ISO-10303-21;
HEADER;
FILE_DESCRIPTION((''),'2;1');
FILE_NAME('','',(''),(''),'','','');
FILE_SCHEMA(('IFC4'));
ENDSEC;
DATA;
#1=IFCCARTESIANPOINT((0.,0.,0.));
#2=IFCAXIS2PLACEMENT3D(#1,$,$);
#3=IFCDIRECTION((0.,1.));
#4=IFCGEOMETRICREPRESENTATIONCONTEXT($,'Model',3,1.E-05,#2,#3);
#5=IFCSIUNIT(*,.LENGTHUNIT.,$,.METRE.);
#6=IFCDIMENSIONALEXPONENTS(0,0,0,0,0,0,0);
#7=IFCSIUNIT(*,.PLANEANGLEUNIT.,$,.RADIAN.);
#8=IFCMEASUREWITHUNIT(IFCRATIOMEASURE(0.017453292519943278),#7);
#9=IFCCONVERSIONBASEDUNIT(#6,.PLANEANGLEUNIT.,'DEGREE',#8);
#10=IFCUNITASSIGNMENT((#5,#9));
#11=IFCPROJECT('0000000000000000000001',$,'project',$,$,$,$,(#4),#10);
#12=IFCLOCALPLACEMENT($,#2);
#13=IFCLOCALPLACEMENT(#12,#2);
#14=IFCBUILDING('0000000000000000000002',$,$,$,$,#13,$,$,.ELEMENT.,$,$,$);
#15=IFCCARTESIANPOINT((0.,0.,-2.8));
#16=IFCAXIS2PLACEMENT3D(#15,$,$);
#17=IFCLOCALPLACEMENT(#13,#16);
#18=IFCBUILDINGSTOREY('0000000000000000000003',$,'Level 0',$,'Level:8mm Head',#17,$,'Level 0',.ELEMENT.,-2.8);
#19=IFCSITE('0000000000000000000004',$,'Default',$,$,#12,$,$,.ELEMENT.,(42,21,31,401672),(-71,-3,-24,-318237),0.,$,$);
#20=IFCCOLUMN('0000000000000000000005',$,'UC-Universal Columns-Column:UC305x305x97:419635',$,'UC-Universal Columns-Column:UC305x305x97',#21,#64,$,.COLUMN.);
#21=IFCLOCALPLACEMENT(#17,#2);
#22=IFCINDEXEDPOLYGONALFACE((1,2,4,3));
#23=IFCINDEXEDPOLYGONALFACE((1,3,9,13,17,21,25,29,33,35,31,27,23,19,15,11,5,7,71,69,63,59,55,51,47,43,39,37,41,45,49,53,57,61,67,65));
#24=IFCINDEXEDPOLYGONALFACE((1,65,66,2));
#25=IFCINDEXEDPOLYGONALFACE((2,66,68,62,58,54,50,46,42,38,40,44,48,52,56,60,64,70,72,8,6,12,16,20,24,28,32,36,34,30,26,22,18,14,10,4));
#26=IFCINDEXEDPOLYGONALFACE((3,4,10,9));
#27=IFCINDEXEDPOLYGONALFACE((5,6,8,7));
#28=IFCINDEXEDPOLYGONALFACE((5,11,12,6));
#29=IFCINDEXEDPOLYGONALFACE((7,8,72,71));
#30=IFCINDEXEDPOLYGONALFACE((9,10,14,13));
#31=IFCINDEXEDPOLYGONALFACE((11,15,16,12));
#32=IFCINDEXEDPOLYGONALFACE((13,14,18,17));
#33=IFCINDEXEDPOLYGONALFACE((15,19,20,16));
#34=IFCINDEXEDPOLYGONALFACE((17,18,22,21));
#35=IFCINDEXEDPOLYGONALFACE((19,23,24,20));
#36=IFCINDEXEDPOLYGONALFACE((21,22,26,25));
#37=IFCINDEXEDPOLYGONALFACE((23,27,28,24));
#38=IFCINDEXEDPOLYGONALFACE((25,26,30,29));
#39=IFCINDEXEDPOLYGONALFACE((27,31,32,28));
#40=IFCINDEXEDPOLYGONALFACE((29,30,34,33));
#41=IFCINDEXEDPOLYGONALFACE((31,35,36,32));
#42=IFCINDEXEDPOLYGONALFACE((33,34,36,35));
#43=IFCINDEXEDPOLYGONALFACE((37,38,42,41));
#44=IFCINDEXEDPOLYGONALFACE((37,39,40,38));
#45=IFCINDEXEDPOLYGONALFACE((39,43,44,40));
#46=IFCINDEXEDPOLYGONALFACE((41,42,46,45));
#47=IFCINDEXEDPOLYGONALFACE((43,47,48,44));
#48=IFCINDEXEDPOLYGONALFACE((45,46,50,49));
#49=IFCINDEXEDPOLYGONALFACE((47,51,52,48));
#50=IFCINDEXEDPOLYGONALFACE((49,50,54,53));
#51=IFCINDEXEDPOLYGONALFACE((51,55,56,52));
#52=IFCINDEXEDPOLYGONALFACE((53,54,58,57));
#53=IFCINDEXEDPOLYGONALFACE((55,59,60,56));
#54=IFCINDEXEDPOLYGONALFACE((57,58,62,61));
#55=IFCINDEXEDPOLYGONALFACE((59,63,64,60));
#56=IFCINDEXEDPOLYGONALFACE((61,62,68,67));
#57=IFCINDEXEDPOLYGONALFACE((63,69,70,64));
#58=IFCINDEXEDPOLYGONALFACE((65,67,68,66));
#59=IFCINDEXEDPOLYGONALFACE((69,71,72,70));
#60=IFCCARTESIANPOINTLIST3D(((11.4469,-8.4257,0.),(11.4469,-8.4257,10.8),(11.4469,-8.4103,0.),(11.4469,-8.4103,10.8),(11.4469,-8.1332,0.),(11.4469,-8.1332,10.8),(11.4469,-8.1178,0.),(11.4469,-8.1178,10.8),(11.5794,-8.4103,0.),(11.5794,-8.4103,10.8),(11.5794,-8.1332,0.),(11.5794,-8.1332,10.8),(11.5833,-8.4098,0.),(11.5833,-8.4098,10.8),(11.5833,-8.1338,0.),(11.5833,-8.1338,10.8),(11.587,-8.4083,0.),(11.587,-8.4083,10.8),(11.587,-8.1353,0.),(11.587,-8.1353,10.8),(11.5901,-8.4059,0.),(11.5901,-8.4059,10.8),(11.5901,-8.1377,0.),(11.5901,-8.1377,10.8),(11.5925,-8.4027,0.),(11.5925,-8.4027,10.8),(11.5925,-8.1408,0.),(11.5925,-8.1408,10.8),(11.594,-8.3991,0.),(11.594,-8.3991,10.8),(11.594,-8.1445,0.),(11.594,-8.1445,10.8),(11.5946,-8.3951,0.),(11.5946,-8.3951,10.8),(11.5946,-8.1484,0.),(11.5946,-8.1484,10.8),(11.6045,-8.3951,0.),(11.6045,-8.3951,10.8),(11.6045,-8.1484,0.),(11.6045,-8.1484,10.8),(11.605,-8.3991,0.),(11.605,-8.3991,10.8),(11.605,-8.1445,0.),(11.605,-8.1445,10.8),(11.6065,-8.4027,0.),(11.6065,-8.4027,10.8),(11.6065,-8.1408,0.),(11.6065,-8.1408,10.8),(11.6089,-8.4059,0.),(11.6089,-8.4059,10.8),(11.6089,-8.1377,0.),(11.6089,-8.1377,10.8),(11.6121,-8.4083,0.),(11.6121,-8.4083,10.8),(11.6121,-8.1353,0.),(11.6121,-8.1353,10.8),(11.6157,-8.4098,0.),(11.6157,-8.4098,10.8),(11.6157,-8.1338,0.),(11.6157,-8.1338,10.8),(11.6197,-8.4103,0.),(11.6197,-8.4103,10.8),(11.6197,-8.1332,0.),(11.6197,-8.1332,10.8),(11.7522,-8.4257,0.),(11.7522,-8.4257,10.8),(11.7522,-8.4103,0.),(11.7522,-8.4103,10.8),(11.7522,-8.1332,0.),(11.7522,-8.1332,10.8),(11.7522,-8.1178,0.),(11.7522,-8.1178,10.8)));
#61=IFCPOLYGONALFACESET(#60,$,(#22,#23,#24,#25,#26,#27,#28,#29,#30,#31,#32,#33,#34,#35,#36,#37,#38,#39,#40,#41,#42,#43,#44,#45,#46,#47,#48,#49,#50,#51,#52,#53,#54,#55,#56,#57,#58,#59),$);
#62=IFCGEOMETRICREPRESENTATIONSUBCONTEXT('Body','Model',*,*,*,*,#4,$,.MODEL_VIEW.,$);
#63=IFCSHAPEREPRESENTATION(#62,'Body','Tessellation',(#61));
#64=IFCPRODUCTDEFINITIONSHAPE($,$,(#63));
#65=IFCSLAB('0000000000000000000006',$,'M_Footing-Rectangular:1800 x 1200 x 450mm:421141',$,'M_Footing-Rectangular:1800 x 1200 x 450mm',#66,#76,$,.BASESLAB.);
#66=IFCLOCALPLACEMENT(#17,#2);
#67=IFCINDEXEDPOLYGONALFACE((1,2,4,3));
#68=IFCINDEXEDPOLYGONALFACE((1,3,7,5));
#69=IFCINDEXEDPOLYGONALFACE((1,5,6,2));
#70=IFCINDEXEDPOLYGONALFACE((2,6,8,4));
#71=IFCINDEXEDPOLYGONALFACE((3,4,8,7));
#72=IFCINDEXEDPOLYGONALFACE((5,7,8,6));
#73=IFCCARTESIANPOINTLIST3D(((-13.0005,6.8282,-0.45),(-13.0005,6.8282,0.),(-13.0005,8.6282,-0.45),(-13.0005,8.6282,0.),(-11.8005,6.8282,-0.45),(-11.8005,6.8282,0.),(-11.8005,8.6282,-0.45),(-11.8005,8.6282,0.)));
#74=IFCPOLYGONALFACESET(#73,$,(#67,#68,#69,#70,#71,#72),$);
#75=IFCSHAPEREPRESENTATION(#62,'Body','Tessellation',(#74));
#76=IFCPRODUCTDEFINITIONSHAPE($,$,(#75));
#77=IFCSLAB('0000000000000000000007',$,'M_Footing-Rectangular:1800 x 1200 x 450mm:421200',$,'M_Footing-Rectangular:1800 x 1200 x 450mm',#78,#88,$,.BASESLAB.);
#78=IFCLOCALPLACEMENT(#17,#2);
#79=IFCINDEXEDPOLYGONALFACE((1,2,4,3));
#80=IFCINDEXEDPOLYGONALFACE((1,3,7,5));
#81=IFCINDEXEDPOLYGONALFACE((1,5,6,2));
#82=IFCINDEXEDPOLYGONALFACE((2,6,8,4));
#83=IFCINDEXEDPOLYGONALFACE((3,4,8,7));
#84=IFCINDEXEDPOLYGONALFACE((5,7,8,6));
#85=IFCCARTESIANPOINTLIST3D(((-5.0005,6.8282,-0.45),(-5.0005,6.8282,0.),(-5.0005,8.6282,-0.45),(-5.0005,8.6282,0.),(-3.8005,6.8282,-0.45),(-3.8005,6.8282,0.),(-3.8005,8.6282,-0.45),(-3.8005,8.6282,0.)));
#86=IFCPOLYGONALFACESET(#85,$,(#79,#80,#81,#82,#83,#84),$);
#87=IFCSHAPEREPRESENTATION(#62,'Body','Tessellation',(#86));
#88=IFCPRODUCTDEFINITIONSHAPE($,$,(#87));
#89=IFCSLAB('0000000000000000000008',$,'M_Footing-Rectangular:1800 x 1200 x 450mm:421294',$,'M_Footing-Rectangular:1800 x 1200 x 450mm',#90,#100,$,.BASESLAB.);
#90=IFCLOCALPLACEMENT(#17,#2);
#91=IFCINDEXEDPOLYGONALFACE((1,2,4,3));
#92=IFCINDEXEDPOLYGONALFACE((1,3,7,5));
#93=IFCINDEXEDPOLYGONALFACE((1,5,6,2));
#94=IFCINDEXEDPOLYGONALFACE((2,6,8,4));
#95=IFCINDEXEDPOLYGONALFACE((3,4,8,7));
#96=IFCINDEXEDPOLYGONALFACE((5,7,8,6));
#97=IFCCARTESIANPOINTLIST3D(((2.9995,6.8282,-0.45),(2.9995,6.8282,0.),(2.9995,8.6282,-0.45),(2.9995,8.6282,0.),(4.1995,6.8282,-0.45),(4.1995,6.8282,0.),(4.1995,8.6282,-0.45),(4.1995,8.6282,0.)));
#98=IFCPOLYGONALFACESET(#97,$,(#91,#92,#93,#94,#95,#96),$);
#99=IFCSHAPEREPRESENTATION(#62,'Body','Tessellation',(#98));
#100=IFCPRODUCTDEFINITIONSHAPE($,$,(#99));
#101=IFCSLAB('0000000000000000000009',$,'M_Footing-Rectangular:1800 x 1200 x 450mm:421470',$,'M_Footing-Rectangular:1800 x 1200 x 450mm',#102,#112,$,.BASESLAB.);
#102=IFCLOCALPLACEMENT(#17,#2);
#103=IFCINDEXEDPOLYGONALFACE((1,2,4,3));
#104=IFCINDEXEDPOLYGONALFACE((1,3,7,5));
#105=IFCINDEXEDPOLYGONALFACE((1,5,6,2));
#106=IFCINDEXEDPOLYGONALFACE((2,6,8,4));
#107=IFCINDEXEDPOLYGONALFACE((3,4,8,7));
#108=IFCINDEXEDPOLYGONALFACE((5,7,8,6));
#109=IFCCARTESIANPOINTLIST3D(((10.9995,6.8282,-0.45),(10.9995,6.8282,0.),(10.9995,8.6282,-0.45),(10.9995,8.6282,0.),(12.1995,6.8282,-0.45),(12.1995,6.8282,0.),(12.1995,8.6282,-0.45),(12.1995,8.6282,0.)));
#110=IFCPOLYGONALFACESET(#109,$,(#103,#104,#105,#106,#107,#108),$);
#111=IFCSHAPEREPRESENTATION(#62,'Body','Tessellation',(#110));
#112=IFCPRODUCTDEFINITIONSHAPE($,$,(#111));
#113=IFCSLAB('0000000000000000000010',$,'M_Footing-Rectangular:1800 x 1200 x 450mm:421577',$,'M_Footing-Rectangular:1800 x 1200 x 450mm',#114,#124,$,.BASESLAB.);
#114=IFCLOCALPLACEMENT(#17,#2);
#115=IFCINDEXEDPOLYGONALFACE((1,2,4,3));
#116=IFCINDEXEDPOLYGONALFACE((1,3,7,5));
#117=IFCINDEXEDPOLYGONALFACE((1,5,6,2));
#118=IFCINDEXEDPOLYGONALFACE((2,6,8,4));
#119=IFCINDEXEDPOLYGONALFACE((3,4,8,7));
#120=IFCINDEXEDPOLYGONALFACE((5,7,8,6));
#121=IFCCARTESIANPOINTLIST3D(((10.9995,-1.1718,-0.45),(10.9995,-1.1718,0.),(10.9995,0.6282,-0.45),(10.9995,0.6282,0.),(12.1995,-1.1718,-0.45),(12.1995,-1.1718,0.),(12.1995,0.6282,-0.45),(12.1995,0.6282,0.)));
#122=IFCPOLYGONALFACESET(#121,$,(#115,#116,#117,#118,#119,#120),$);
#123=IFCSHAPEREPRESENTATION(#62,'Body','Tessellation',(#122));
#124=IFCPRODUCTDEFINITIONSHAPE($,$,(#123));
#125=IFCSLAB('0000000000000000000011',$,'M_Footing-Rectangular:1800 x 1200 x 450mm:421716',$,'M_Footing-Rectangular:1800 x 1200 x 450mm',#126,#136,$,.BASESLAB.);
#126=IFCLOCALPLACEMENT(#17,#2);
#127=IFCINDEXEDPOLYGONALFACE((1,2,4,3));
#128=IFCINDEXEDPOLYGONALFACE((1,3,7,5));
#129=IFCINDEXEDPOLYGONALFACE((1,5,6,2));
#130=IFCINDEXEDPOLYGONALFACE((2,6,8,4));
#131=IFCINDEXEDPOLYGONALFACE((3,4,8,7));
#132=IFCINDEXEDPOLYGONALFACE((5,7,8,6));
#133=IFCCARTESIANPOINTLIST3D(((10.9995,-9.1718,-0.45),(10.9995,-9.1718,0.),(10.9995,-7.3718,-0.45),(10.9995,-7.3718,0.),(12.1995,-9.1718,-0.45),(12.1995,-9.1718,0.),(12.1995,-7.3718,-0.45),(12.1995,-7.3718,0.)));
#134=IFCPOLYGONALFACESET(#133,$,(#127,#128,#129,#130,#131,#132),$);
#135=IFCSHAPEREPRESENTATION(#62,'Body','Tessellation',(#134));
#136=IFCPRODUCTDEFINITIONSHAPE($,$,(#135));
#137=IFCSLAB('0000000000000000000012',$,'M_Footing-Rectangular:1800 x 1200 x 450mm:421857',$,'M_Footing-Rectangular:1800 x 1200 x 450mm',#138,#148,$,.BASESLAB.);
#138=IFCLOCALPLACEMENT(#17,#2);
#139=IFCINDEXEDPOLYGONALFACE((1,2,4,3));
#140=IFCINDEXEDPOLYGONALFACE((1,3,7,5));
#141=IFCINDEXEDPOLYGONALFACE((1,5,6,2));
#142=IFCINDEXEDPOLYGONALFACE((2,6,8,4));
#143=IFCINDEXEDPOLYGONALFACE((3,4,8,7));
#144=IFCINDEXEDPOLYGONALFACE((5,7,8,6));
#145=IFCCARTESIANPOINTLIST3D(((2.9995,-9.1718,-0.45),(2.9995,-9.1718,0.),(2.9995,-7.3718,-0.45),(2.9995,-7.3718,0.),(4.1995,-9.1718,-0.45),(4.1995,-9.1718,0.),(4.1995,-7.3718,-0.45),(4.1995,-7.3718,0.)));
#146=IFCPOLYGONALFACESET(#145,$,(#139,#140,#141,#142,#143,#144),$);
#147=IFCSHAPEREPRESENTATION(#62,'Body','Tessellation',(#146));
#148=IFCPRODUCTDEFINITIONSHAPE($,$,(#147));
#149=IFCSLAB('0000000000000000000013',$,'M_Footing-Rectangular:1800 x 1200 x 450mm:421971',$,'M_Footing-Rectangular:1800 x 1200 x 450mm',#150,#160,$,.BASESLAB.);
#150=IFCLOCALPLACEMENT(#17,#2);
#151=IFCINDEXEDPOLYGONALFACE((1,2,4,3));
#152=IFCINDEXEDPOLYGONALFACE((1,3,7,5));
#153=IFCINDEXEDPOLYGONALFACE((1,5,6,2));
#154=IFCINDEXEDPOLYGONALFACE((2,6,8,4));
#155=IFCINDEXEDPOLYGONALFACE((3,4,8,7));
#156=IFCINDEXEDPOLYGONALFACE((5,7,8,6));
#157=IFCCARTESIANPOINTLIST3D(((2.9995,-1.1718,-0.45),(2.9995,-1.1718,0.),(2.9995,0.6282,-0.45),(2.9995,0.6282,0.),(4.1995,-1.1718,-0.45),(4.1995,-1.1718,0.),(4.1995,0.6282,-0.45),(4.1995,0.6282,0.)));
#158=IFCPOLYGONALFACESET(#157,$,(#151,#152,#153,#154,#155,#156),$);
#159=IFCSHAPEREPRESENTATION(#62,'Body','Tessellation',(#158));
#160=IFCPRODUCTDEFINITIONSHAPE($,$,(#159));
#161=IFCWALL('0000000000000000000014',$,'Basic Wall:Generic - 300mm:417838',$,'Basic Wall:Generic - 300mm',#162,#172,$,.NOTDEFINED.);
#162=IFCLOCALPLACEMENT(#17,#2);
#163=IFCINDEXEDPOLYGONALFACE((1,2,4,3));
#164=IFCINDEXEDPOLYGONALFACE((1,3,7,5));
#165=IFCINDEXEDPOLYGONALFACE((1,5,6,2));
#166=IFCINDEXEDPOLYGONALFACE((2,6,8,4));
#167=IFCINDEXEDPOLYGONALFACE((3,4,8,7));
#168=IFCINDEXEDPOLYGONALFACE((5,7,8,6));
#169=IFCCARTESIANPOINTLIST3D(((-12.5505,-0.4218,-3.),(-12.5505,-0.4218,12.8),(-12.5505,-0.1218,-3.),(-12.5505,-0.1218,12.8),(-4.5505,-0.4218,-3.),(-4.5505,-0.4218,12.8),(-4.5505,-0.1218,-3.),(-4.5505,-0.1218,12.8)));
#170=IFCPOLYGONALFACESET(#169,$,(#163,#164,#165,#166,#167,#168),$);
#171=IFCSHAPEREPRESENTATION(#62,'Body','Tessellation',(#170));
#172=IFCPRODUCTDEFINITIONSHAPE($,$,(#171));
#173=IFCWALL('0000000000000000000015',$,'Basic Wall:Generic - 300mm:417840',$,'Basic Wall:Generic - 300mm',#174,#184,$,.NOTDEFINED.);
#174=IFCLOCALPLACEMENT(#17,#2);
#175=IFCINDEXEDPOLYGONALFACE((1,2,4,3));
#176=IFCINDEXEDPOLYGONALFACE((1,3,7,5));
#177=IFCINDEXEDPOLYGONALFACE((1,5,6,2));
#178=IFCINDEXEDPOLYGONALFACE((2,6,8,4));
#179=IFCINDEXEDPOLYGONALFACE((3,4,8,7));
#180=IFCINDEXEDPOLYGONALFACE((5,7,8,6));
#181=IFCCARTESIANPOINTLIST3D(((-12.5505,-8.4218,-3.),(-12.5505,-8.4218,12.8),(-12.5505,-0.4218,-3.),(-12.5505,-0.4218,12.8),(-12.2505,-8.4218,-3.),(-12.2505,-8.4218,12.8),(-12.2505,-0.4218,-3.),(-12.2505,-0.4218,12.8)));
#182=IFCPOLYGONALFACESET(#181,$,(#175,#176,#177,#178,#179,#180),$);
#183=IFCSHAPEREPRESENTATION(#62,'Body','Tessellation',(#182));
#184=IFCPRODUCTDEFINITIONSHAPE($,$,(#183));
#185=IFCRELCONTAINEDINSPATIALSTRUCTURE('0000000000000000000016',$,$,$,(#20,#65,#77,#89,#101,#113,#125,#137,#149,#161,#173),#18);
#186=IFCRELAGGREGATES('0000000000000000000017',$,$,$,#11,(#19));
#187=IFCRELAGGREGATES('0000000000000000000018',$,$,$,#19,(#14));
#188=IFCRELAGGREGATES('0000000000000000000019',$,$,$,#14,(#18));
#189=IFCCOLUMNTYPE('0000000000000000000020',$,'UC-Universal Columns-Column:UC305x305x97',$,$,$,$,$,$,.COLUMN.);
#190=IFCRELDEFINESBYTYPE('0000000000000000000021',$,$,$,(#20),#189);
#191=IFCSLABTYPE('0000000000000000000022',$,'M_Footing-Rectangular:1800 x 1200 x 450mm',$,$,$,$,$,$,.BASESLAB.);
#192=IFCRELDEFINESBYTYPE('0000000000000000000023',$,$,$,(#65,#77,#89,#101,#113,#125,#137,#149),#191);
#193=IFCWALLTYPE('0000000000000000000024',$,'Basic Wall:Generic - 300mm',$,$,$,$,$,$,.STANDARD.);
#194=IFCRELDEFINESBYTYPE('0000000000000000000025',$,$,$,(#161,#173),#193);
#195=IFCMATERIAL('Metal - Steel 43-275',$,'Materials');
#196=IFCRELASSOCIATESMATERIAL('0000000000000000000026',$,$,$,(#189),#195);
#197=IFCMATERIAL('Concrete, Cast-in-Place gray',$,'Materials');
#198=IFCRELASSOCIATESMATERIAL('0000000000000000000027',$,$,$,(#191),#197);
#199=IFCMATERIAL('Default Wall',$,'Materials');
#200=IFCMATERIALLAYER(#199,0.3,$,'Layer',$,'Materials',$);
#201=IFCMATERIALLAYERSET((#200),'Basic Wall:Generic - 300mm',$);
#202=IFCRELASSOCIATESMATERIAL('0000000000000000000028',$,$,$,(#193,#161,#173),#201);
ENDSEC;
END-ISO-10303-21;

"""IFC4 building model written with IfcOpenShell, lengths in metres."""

from ifc_helpers import new_model, entity, si_unit, converted_unit, direction, frame, frame_2d, origin, origin_2d_with_axis, place, context, subcontext, project, spatial, rectangle, i_section, extrude, source, transform, mapped, material, layer, layer_set, layer_usage, material_profile, profile_set, type_object, type_shapes, element, save


model = new_model("IFC4")

# Units and contexts
model_context = context("Model", 3, precision=1e-05, world=origin(), true_north=direction((0.0, 1.0)))
body_context = subcontext(model_context, "Body", "Model", "MODEL_VIEW")
ifc_project = project(units=[si_unit("LENGTHUNIT", "METRE"), converted_unit("PLANEANGLEUNIT", "DEGREE", entity("IfcRatioMeasure", 0.017453292519943278), si_unit("PLANEANGLEUNIT", "RADIAN"), dimensions=[0, 0, 0, 0, 0, 0, 0])], contexts=[model_context])

# Site, building, storey
site_placement = place(None, origin())
site = spatial("IfcSite", under=ifc_project, at=site_placement, Name="Default", CompositionType="ELEMENT", RefLatitude=(42, 21, 31, 401672), RefLongitude=(-71, -3, -24, -318237), RefElevation=0.0)
building_placement = place(site_placement, origin())
building = spatial("IfcBuilding", under=site, at=building_placement, CompositionType="ELEMENT")
storey_placement = place(building_placement, frame((0.0, 0.0, -2.8)))
storey = spatial("IfcBuildingStorey", under=building, at=storey_placement, Name="Level 0", ObjectType="Level:8mm Head", LongName="Level 0", CompositionType="ELEMENT", Elevation=-2.8)

# Column
ifc_material_1 = material(Name="Metal - Steel 43-275", Category="Materials")
ifc_material_profile = material_profile(ifc_material_1, i_section(OverallWidth=0.3053, OverallDepth=0.3079, WebThickness=0.0099, FlangeThickness=0.0154, FilletRadius=0.0152, at=frame_2d((0.0, 0.0), x_axis=(0.0, 1.0))), Name="UC305x305x97")
ifc_profile_set = profile_set([ifc_material_profile], Name="UC305x305x97")
column_type = type_object("IfcColumnType", Name="UC-Universal Columns-Column:UC305x305x97", PredefinedType="COLUMN", material=ifc_profile_set)
shared_shape = source(origin(), body_context, "Body", "SweptSolid", [
    extrude(i_section(OverallWidth=0.3053, OverallDepth=0.3079, WebThickness=0.0099, FlangeThickness=0.0154, FilletRadius=0.0152, at=frame_2d((0.0, 0.0), x_axis=(0.0, 1.0))), frame((0.0, 0.0, -2.8), z_axis=(0.0, 0.0, 1.0), x_axis=(0.0, -1.0, 0.0)), (0.0, 0.0, 1.0), 10.8),
])
type_shapes(column_type, [shared_shape])
for number, where, name in (
    (1, (11.5995, -8.2718, 2.8), "UC-Universal Columns-Column:UC305x305x97:419635"),
):
    element("IfcColumn", number, at=place(storey_placement, frame(where)), inside=storey, type_object=column_type, Name=name, ObjectType="UC-Universal Columns-Column:UC305x305x97", PredefinedType="COLUMN", context=body_context, shape_type="MappedRepresentation", body=[
        mapped(shared_shape, transform((0.0, 0.0, 0.0), scale=1.0)),
    ])

# Slabs
ifc_material_2 = material(Name="Concrete, Cast-in-Place gray", Category="Materials")
slab_type = type_object("IfcSlabType", Name="M_Footing-Rectangular:1800 x 1200 x 450mm", PredefinedType="BASESLAB", material=ifc_material_2)
slab_1_placement = place(storey_placement, frame((-13.0005, 6.8282, -0.45)))
element("IfcSlab", 2, at=slab_1_placement, inside=storey, type_object=slab_type, Name="M_Footing-Rectangular:1800 x 1200 x 450mm:421141", ObjectType="M_Footing-Rectangular:1800 x 1200 x 450mm", PredefinedType="BASESLAB", context=body_context, shape_type="SweptSolid", body=[
    extrude(rectangle(XDim=1.2, YDim=1.8, at=frame_2d((0.0, 0.0), x_axis=(1.0, 0.0))), frame((0.6, 0.9, 0.0), z_axis=(0.0, 0.0, 1.0), x_axis=(-1.0, 0.0, 0.0)), (0.0, 0.0, 1.0), 0.45),
])
for number, where, name in (
    (3, (-5.0005, 6.8282, -0.45), "M_Footing-Rectangular:1800 x 1200 x 450mm:421200"),
    (4, (2.9995, 6.8282, -0.45), "M_Footing-Rectangular:1800 x 1200 x 450mm:421294"),
):
    element("IfcSlab", number, at=place(storey_placement, frame(where)), inside=storey, type_object=slab_type, Name=name, ObjectType="M_Footing-Rectangular:1800 x 1200 x 450mm", PredefinedType="BASESLAB", context=body_context, shape_type="SweptSolid", body=[
        extrude(rectangle(XDim=1.2, YDim=1.8, at=frame_2d((0.0, 0.0), x_axis=(1.0, 0.0))), frame((0.6, 0.9, 0.0), z_axis=(0.0, 0.0, 1.0), x_axis=(-1.0, 0.0, 0.0)), (0.0, 0.0, 1.0), 0.45),
    ])
slab_2_placement = place(storey_placement, frame((10.9995, 6.8282, -0.45)))
element("IfcSlab", 5, at=slab_2_placement, inside=storey, type_object=slab_type, Name="M_Footing-Rectangular:1800 x 1200 x 450mm:421470", ObjectType="M_Footing-Rectangular:1800 x 1200 x 450mm", PredefinedType="BASESLAB", context=body_context, shape_type="SweptSolid", body=[
    extrude(rectangle(XDim=1.2, YDim=1.8, at=frame_2d((0.0, 0.0), x_axis=(1.0, 0.0))), frame((0.6, 0.9, 0.0), z_axis=(0.0, 0.0, 1.0), x_axis=(-1.0, 0.0, 0.0)), (0.0, 0.0, 1.0), 0.45),
])
slab_3_placement = place(storey_placement, frame((10.9995, -1.1718, -0.45)))
element("IfcSlab", 6, at=slab_3_placement, inside=storey, type_object=slab_type, Name="M_Footing-Rectangular:1800 x 1200 x 450mm:421577", ObjectType="M_Footing-Rectangular:1800 x 1200 x 450mm", PredefinedType="BASESLAB", context=body_context, shape_type="SweptSolid", body=[
    extrude(rectangle(XDim=1.2, YDim=1.8, at=origin_2d_with_axis()), frame((0.6, 0.9, 0.0), z_axis=(0.0, 0.0, 1.0), x_axis=(-1.0, 0.0, 0.0)), (0.0, 0.0, 1.0), 0.45),
])
slab_4_placement = place(storey_placement, frame((10.9995, -9.1718, -0.45)))
element("IfcSlab", 7, at=slab_4_placement, inside=storey, type_object=slab_type, Name="M_Footing-Rectangular:1800 x 1200 x 450mm:421716", ObjectType="M_Footing-Rectangular:1800 x 1200 x 450mm", PredefinedType="BASESLAB", context=body_context, shape_type="SweptSolid", body=[
    extrude(rectangle(XDim=1.2, YDim=1.8, at=origin_2d_with_axis()), frame((0.6, 0.9, 0.0), z_axis=(0.0, 0.0, 1.0), x_axis=(-1.0, 0.0, 0.0)), (0.0, 0.0, 1.0), 0.45),
])
slab_5_placement = place(storey_placement, frame((2.9995, -9.1718, -0.45)))
element("IfcSlab", 8, at=slab_5_placement, inside=storey, type_object=slab_type, Name="M_Footing-Rectangular:1800 x 1200 x 450mm:421857", ObjectType="M_Footing-Rectangular:1800 x 1200 x 450mm", PredefinedType="BASESLAB", context=body_context, shape_type="SweptSolid", body=[
    extrude(rectangle(XDim=1.2, YDim=1.8, at=frame_2d((0.0, 0.0), x_axis=(1.0, 0.0))), frame((0.6, 0.9, 0.0), z_axis=(0.0, 0.0, 1.0), x_axis=(-1.0, 0.0, 0.0)), (0.0, 0.0, 1.0), 0.45),
])
slab_6_placement = place(storey_placement, frame((2.9995, -1.1718, -0.45)))
element("IfcSlab", 9, at=slab_6_placement, inside=storey, type_object=slab_type, Name="M_Footing-Rectangular:1800 x 1200 x 450mm:421971", ObjectType="M_Footing-Rectangular:1800 x 1200 x 450mm", PredefinedType="BASESLAB", context=body_context, shape_type="SweptSolid", body=[
    extrude(rectangle(XDim=1.2, YDim=1.8, at=frame_2d((0.0, 0.0), x_axis=(1.0, 0.0))), frame((0.6, 0.9, 0.0), z_axis=(0.0, 0.0, 1.0), x_axis=(-1.0, 0.0, 0.0)), (0.0, 0.0, 1.0), 0.45),
])

# Walls
ifc_material_3 = material(Name="Default Wall", Category="Materials")
ifc_layer = layer(ifc_material_3, 0.3, Name="Layer", Category="Materials")
ifc_layer_set = layer_set([ifc_layer], Name="Basic Wall:Generic - 300mm")
ifc_layer_usage = layer_usage(ifc_layer_set, "AXIS2", "NEGATIVE", 0.15)
wall_type = type_object("IfcWallType", Name="Basic Wall:Generic - 300mm", PredefinedType="STANDARD", material=ifc_layer_set)
wall_1_placement = place(storey_placement, frame((-12.5505, -0.2718, -3.0)))
element("IfcWall", 10, at=wall_1_placement, inside=storey, type_object=wall_type, material=ifc_layer_usage, Name="Basic Wall:Generic - 300mm:417838", ObjectType="Basic Wall:Generic - 300mm", PredefinedType="NOTDEFINED", context=body_context, shape_type="SweptSolid", body=[
    extrude(rectangle(XDim=8.0, YDim=0.3, at=frame_2d((4.0, 0.0), x_axis=(-1.0, 0.0))), origin(), (0.0, 0.0, 1.0), 15.8),
])
wall_2_placement = place(storey_placement, frame((-12.4005, -8.4218, -3.0), z_axis=(0.0, 0.0, 1.0), x_axis=(0.0, 1.0, 0.0)))
element("IfcWall", 11, at=wall_2_placement, inside=storey, type_object=wall_type, material=ifc_layer_usage, Name="Basic Wall:Generic - 300mm:417840", ObjectType="Basic Wall:Generic - 300mm", PredefinedType="NOTDEFINED", context=body_context, shape_type="SweptSolid", body=[
    extrude(rectangle(XDim=8.0, YDim=0.3, at=frame_2d((4.0, 0.0), x_axis=(-1.0, 0.0))), origin(), (0.0, 0.0, 1.0), 15.8),
])

save(model, "model.ifc")
